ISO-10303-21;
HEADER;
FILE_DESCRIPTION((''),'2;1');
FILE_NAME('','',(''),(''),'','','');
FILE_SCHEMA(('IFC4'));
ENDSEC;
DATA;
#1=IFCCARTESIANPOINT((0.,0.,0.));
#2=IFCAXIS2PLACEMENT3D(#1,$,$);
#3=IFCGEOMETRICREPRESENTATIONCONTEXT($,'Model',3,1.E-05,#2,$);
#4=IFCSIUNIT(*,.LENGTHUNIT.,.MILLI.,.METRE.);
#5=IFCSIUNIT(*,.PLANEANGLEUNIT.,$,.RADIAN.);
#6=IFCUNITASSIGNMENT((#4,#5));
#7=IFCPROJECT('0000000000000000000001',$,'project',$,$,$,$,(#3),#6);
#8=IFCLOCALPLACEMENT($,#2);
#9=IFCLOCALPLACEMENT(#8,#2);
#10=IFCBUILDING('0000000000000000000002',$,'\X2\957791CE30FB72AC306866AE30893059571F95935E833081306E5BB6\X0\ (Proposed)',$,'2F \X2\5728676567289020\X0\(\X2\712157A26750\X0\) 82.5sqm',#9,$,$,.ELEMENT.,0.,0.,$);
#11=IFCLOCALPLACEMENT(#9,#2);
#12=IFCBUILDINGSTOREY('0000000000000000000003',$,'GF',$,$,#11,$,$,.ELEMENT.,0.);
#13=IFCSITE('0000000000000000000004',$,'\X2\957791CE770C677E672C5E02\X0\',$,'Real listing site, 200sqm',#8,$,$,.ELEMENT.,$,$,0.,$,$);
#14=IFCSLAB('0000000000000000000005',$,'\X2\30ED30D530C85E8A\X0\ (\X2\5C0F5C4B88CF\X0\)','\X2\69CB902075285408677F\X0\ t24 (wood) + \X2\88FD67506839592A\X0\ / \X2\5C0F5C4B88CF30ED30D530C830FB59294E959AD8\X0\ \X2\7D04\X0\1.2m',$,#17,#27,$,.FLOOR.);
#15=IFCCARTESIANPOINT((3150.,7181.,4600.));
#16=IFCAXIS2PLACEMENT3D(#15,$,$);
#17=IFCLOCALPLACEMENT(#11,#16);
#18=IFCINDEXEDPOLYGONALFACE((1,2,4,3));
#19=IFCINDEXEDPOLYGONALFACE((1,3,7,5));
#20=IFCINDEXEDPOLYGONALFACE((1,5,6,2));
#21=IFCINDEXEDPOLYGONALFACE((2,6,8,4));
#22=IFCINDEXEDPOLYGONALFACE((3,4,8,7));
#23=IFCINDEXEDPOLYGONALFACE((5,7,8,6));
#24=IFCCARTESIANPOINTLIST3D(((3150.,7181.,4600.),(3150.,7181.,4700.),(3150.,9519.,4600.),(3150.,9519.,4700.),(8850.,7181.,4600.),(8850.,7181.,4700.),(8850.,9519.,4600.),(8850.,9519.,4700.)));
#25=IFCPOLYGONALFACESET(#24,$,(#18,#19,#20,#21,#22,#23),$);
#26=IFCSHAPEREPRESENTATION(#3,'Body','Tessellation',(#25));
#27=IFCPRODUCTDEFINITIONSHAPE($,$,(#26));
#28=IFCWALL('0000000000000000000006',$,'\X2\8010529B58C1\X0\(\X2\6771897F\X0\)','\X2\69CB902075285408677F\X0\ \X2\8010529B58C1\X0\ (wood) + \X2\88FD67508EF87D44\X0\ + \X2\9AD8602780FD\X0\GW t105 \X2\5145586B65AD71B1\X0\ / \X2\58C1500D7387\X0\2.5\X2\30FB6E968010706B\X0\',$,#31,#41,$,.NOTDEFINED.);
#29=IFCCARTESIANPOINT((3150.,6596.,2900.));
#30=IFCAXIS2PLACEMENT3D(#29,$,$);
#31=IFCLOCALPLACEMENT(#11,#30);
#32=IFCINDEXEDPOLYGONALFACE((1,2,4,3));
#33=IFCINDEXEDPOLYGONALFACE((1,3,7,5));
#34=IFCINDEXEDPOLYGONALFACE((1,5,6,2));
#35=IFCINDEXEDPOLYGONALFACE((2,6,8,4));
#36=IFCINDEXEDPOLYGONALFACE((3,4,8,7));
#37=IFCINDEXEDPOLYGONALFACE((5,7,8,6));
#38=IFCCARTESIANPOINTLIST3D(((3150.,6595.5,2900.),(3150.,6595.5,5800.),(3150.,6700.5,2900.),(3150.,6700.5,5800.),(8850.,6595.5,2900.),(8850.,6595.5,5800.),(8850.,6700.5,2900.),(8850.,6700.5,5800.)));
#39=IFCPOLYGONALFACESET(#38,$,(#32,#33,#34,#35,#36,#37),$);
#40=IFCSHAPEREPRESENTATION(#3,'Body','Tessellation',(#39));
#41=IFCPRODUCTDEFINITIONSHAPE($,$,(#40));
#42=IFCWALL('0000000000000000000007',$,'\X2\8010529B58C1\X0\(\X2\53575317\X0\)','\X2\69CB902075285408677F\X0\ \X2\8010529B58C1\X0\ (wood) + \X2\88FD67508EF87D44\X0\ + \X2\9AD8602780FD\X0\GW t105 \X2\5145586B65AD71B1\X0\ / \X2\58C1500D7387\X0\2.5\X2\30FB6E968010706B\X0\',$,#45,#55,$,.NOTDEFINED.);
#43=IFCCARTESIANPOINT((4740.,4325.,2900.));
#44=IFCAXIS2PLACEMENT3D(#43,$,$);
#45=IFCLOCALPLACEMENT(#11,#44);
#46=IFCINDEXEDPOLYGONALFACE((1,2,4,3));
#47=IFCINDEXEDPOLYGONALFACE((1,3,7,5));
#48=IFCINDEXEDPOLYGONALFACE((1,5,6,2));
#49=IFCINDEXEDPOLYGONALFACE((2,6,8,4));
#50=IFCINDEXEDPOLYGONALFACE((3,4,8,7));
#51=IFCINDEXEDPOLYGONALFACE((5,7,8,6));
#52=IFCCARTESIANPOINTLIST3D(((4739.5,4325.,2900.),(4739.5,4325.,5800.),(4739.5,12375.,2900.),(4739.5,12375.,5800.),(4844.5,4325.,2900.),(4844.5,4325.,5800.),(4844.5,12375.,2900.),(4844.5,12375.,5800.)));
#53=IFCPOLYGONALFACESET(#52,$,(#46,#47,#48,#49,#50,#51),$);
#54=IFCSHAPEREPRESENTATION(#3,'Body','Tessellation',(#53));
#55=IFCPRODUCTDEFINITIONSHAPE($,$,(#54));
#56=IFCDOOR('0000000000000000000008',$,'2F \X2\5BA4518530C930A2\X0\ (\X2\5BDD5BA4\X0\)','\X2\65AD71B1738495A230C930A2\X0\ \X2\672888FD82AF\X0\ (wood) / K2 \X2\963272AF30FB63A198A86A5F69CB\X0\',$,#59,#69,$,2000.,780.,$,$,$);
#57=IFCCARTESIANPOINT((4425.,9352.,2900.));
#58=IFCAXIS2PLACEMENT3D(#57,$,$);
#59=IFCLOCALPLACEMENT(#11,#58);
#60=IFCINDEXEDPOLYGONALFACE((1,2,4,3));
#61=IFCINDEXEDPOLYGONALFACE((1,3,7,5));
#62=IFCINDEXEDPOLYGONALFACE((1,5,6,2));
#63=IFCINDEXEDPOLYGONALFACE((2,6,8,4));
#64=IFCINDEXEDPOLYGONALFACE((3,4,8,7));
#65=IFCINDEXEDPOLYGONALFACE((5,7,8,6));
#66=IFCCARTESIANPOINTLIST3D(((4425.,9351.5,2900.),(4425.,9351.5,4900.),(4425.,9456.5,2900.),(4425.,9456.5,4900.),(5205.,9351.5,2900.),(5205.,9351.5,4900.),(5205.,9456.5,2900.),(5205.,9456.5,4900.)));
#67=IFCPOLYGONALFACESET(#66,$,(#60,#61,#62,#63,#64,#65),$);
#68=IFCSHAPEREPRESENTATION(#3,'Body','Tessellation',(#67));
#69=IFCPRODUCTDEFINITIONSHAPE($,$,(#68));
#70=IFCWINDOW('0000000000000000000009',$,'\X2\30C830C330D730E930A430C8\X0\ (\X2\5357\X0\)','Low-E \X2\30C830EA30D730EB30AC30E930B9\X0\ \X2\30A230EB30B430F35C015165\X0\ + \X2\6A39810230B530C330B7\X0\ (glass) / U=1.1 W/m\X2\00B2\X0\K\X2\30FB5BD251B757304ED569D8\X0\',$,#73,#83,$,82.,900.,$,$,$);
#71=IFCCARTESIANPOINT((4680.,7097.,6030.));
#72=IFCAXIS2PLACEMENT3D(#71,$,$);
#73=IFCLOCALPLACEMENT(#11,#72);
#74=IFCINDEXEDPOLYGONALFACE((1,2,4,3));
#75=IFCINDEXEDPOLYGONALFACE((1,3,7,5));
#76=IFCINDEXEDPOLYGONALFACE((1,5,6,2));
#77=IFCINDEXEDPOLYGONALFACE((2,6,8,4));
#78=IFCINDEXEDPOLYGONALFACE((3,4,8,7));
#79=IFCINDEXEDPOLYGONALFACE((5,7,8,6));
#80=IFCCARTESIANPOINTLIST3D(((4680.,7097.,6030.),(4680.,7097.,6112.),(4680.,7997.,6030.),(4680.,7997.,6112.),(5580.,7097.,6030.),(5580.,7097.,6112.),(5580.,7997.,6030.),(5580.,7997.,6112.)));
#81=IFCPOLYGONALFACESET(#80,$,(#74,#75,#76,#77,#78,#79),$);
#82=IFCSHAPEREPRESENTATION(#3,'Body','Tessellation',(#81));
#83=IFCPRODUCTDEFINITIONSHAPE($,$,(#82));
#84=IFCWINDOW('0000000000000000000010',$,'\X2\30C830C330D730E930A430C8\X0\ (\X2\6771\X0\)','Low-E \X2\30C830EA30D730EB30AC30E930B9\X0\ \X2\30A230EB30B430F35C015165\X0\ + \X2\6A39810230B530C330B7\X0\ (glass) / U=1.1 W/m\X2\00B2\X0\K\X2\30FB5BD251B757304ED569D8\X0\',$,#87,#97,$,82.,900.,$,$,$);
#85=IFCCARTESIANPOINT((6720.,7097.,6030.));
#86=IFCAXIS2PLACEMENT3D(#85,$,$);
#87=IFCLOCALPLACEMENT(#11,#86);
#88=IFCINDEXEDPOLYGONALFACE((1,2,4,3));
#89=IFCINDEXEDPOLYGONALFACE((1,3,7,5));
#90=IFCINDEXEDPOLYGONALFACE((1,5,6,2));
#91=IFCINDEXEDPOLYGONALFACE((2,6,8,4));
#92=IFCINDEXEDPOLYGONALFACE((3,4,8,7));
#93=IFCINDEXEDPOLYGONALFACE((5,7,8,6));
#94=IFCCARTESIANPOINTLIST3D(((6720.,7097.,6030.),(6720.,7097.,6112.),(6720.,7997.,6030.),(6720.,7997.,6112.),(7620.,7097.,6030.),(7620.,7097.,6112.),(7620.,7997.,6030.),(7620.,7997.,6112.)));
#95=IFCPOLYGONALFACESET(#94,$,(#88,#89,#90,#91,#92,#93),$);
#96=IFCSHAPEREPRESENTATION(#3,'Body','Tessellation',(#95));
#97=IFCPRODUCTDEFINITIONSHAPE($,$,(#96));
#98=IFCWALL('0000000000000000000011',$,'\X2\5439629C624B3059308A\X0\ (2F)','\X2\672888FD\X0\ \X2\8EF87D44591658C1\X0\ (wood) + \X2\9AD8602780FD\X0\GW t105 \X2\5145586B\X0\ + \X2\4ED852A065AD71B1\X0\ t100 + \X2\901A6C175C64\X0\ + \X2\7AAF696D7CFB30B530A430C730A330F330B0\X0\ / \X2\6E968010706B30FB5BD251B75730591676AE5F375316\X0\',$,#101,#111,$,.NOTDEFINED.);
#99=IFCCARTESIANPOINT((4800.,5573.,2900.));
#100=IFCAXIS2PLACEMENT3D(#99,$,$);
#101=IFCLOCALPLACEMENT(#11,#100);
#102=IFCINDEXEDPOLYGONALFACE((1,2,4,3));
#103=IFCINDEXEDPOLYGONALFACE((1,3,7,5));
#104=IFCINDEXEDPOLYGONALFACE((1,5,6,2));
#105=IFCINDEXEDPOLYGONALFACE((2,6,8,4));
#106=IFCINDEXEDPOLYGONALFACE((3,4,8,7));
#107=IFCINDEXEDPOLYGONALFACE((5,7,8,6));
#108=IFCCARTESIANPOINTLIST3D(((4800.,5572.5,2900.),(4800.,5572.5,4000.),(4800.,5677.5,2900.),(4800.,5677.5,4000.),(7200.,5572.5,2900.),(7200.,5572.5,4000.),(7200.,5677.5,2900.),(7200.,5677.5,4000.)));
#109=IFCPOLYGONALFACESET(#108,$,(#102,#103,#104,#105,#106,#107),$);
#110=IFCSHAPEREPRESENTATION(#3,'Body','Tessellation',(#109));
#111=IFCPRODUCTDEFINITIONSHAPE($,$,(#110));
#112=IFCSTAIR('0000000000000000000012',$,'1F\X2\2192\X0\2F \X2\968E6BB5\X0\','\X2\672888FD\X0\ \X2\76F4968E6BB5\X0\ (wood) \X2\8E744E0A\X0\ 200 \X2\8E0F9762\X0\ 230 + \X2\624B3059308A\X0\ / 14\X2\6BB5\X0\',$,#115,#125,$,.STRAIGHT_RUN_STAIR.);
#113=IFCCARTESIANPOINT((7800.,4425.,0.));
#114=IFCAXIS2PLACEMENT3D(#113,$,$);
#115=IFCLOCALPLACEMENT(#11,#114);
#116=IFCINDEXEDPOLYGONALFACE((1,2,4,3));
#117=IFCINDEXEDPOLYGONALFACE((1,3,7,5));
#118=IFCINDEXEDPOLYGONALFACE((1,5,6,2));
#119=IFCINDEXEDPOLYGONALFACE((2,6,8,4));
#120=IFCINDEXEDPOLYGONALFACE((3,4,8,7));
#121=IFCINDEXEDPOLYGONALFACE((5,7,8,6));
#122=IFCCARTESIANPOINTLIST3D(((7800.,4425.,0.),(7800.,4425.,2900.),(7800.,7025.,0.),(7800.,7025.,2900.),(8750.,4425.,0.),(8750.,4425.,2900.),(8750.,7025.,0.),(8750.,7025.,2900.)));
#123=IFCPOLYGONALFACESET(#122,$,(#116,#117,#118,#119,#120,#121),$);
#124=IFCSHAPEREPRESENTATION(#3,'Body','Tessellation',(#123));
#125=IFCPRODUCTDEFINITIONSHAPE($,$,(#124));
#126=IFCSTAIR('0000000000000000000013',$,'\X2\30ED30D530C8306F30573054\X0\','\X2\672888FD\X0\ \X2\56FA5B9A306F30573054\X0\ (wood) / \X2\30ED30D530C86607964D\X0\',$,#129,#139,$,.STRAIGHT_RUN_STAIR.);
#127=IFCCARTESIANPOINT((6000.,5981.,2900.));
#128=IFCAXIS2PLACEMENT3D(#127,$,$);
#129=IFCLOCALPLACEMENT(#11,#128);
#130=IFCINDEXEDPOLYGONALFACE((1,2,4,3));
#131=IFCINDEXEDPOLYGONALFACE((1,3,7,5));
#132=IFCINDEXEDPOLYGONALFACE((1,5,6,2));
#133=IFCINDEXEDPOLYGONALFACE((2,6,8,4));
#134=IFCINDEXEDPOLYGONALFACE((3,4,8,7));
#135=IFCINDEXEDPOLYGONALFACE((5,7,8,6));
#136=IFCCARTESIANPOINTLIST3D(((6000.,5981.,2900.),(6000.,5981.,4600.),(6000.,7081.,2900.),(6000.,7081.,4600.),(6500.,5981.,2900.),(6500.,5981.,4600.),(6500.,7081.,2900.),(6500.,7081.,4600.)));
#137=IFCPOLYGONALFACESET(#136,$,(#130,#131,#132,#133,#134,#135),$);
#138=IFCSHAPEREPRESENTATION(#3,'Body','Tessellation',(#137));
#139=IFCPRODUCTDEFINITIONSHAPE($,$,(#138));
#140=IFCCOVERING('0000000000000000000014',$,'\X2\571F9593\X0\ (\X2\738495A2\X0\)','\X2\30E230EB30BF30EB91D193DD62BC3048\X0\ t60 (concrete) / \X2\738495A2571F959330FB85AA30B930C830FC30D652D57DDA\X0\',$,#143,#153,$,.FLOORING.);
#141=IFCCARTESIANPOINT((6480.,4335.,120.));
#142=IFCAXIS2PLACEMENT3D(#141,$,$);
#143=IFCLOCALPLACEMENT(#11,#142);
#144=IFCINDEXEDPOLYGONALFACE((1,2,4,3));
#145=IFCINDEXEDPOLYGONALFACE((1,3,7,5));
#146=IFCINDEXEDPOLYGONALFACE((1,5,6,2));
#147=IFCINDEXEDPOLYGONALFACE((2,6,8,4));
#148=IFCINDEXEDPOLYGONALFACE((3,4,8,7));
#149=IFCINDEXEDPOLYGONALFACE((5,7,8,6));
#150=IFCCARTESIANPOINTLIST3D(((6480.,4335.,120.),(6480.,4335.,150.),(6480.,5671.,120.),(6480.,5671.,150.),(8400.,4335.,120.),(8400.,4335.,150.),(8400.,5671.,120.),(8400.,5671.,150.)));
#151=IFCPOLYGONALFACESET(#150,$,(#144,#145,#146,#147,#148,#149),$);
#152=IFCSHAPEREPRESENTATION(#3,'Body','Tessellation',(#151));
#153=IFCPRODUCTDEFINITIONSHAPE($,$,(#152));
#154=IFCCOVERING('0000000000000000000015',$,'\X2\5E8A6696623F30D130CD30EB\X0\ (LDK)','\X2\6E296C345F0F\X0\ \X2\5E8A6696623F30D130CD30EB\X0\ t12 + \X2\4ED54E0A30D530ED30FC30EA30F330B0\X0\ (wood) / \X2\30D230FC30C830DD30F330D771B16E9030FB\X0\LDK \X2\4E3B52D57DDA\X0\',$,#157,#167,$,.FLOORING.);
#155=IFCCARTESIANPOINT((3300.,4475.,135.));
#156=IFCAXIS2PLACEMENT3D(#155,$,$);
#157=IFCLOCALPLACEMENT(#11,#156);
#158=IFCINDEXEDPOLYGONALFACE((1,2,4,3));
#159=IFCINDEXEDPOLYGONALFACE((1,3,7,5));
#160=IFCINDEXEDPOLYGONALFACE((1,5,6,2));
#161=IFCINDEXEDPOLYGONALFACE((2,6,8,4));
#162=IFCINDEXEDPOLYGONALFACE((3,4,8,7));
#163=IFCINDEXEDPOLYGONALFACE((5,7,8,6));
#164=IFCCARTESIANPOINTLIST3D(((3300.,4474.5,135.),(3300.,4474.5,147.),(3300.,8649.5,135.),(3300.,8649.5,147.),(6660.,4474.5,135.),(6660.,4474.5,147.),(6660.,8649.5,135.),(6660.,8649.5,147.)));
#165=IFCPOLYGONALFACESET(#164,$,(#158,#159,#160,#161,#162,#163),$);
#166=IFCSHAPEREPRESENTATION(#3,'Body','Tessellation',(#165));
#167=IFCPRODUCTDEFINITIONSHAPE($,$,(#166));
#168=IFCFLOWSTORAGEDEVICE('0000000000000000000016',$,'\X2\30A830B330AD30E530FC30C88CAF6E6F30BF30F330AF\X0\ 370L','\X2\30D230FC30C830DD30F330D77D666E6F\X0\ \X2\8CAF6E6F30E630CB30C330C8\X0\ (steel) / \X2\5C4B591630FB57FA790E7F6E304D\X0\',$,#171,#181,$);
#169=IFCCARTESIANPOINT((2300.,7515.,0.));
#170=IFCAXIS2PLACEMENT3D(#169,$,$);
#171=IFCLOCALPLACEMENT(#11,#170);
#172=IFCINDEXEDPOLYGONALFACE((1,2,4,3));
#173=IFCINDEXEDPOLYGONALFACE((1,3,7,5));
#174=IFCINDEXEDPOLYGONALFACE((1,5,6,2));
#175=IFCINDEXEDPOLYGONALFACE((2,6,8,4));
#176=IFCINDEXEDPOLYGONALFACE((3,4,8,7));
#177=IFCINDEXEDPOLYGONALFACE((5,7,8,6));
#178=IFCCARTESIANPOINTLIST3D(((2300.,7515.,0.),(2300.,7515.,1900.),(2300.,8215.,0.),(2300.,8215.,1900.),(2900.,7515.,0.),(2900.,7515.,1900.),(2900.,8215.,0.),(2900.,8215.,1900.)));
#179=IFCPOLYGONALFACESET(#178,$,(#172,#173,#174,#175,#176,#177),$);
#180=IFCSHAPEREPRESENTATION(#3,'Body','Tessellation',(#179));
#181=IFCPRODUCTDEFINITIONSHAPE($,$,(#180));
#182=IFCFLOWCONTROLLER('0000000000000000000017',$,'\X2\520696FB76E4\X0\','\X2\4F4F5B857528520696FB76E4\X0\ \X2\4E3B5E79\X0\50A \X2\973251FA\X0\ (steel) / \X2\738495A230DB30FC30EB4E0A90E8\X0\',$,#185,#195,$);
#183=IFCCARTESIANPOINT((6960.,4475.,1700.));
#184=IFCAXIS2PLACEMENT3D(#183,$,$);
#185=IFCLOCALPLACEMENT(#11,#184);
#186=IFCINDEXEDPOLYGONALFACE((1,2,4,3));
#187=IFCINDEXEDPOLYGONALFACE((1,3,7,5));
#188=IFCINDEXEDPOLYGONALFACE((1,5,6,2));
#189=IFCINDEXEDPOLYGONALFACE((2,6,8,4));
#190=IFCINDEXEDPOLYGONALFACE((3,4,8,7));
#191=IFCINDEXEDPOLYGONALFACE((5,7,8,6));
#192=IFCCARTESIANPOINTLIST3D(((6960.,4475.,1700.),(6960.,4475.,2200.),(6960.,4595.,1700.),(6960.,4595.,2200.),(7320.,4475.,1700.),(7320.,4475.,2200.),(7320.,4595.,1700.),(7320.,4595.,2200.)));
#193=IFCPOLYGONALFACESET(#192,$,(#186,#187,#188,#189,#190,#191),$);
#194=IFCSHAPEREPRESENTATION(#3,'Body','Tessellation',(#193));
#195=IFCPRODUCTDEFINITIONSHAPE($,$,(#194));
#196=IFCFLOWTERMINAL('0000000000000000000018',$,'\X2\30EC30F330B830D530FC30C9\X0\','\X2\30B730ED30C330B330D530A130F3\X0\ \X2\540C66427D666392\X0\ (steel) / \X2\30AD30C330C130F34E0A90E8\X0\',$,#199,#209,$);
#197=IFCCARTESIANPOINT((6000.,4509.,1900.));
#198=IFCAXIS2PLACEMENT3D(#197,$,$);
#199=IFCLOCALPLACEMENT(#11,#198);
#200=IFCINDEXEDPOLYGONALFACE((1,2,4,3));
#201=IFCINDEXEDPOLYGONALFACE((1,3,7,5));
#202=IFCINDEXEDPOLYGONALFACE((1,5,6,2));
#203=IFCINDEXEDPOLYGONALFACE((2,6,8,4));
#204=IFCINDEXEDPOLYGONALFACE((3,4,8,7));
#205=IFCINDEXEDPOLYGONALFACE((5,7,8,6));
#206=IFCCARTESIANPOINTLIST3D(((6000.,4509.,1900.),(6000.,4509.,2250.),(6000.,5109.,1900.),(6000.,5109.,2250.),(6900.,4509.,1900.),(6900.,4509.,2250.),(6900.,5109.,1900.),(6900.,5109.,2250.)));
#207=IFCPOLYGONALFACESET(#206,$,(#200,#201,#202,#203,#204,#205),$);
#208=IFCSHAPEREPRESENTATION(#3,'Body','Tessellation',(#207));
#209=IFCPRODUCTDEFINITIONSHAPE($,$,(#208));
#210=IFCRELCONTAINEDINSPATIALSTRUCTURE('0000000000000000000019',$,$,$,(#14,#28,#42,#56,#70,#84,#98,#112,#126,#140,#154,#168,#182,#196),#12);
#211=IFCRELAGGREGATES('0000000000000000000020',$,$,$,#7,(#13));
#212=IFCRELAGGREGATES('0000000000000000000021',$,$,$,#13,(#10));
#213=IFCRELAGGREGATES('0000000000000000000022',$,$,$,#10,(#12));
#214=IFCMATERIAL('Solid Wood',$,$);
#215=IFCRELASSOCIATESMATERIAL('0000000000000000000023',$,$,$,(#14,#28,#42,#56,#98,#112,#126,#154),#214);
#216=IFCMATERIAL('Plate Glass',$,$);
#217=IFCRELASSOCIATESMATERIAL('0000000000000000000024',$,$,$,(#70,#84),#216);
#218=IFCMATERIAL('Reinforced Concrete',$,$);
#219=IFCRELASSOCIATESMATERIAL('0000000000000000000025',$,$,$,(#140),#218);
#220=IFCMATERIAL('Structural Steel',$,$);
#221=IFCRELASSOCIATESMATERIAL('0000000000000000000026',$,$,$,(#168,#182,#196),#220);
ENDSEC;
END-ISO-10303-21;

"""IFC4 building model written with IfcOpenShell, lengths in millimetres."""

from ifc_helpers import new_model, si_unit, frame, frame_2d, origin, place, context, project, spatial, rectangle, extrude, material, element, fill, save


model = new_model("IFC4")

# Units and contexts
model_context = context("Model", 3, precision=1e-05, world=origin())
ifc_project = project(units=[si_unit("LENGTHUNIT", "METRE", prefix="MILLI"), si_unit("PLANEANGLEUNIT", "RADIAN")], contexts=[model_context])

# Site, building, storey
site_placement = place(None, origin())
site = spatial("IfcSite", under=ifc_project, at=site_placement, Name="長野県松本市", ObjectType="Real listing site, 200sqm", CompositionType="ELEMENT", RefElevation=0.0)
building_placement = place(site_placement, origin())
building = spatial("IfcBuilding", under=site, at=building_placement, Name="長野・犬と暮らす土間広めの家 (Proposed)", ObjectType="2F 在来木造(無垢材) 82.5sqm", CompositionType="ELEMENT", ElevationOfRefHeight=0.0, ElevationOfTerrain=0.0)
storey_placement = place(building_placement, origin())
storey = spatial("IfcBuildingStorey", under=building, at=storey_placement, Name="GF", CompositionType="ELEMENT", Elevation=0.0)

# Shared definitions
ifc_material_1 = material(Name="Solid Wood")

# Slab
slab_placement = place(storey_placement, frame((3150.0, 7181.0, 4600.0)))
element("IfcSlab", 1, at=slab_placement, inside=storey, material=ifc_material_1, Name="ロフト床 (小屋裏)", Description="構造用合板 t24 (wood) + 製材根太 / 小屋裏ロフト・天井高 約1.2m", PredefinedType="FLOOR", context=model_context, shape_type="SweptSolid", body=[
    extrude(rectangle(XDim=5700.0, YDim=2338.0, at=frame_2d((2850.0, 1169.0))), frame((3150.0, 7181.0, 4600.0)), (0.0, 0.0, 1.0), 100.0),
])

# Wall
wall_1_placement = place(storey_placement, frame((3150.0, 6596.0, 2900.0)))
element("IfcWall", 2, at=wall_1_placement, inside=storey, material=ifc_material_1, Name="耐力壁(東西)", Description="構造用合板 耐力壁 (wood) + 製材軸組 + 高性能GW t105 充填断熱 / 壁倍率2.5・準耐火", PredefinedType="NOTDEFINED", context=model_context, shape_type="SweptSolid", body=[
    extrude(rectangle(XDim=5700.0, YDim=105.0, at=frame_2d((2850.0, 52.0))), frame((3150.0, 6596.0, 2900.0)), (0.0, 0.0, 1.0), 2900.0),
])

# Wall, opening, door
wall_2_placement = place(storey_placement, frame((4740.0, 4325.0, 2900.0)))
wall_2 = element("IfcWall", 3, at=wall_2_placement, inside=storey, material=ifc_material_1, Name="耐力壁(南北)", Description="構造用合板 耐力壁 (wood) + 製材軸組 + 高性能GW t105 充填断熱 / 壁倍率2.5・準耐火", PredefinedType="NOTDEFINED", context=model_context, shape_type="SweptSolid", body=[
    extrude(rectangle(XDim=105.0, YDim=8050.0, at=frame_2d((52.0, 4025.0))), frame((4740.0, 4325.0, 2900.0)), (0.0, 0.0, 1.0), 2900.0),
])
opening_placement = place(storey_placement, frame((4425.0, 9352.0, 2900.0)))
opening = element("IfcOpeningElement", 4, at=opening_placement, cuts=wall_2, PredefinedType="NOTDEFINED", context=model_context, shape_type="SweptSolid", body=[
    extrude(rectangle(XDim=780.0, YDim=105.0, at=frame_2d((390.0, 52.0))), frame((4425.0, 9352.0, 2900.0)), (0.0, 0.0, 1.0), 2000.0),
])
door_placement = place(storey_placement, frame((4425.0, 9352.0, 2900.0)))
door = element("IfcDoor", 5, at=door_placement, inside=storey, material=ifc_material_1, Name="2F 室内ドア (寝室)", Description="断熱玄関ドア 木製芯 (wood) / K2 防犯・採風機構", OverallHeight=2000.0, OverallWidth=780.0, context=model_context, shape_type="SweptSolid", body=[
    extrude(rectangle(XDim=780.0, YDim=105.0, at=frame_2d((390.0, 52.0))), frame((4425.0, 9352.0, 2900.0)), (0.0, 0.0, 1.0), 2000.0),
])
fill(opening, door)

# Windows
ifc_material_2 = material(Name="Plate Glass")
window_1_placement = place(storey_placement, frame((4680.0, 7097.0, 6030.0)))
element("IfcWindow", 6, at=window_1_placement, inside=storey, material=ifc_material_2, Name="トップライト (南)", Description="Low-E トリプルガラス アルゴン封入 + 樹脂サッシ (glass) / U=1.1 W/m²K・寒冷地仕様", OverallHeight=82.0, OverallWidth=900.0, context=model_context, shape_type="SweptSolid", body=[
    extrude(rectangle(XDim=900.0, YDim=900.0, at=frame_2d((450.0, 450.0))), frame((4680.0, 7097.0, 6030.0)), (0.0, 0.0, 1.0), 82.0),
])
window_2_placement = place(storey_placement, frame((6720.0, 7097.0, 6030.0)))
element("IfcWindow", 7, at=window_2_placement, inside=storey, material=ifc_material_2, Name="トップライト (東)", Description="Low-E トリプルガラス アルゴン封入 + 樹脂サッシ (glass) / U=1.1 W/m²K・寒冷地仕様", OverallHeight=82.0, OverallWidth=900.0, context=model_context, shape_type="SweptSolid", body=[
    extrude(rectangle(XDim=900.0, YDim=900.0, at=frame_2d((450.0, 450.0))), frame((6720.0, 7097.0, 6030.0)), (0.0, 0.0, 1.0), 82.0),
])

# Wall
wall_3_placement = place(storey_placement, frame((4800.0, 5573.0, 2900.0)))
element("IfcWall", 8, at=wall_3_placement, inside=storey, material=ifc_material_1, Name="吹抜手すり (2F)", Description="木製 軸組外壁 (wood) + 高性能GW t105 充填 + 付加断熱 t100 + 通気層 + 窯業系サイディング / 準耐火・寒冷地外皮強化", PredefinedType="NOTDEFINED", context=model_context, shape_type="SweptSolid", body=[
    extrude(rectangle(XDim=2400.0, YDim=105.0, at=frame_2d((1200.0, 52.0))), frame((4800.0, 5573.0, 2900.0)), (0.0, 0.0, 1.0), 1100.0),
])

# Stairs
stair_1_placement = place(storey_placement, frame((7800.0, 4425.0, 0.0)))
element("IfcStair", 9, at=stair_1_placement, inside=storey, material=ifc_material_1, Name="1F→2F 階段", Description="木製 直階段 (wood) 蹴上 200 踏面 230 + 手すり / 14段", PredefinedType="STRAIGHT_RUN_STAIR", context=model_context, shape_type="SweptSolid", body=[
    extrude(rectangle(XDim=950.0, YDim=2600.0, at=frame_2d((475.0, 1300.0))), frame((7800.0, 4425.0, 0.0)), (0.0, 0.0, 1.0), 2900.0),
])
stair_2_placement = place(storey_placement, frame((6000.0, 5981.0, 2900.0)))
element("IfcStair", 10, at=stair_2_placement, inside=storey, material=ifc_material_1, Name="ロフトはしご", Description="木製 固定はしご (wood) / ロフト昇降", PredefinedType="STRAIGHT_RUN_STAIR", context=model_context, shape_type="SweptSolid", body=[
    extrude(rectangle(XDim=500.0, YDim=1100.0, at=frame_2d((250.0, 550.0))), frame((6000.0, 5981.0, 2900.0)), (0.0, 0.0, 1.0), 1700.0),
])

# Coverings
ifc_material_3 = material(Name="Reinforced Concrete")
covering_1_placement = place(storey_placement, frame((6480.0, 4335.0, 120.0)))
element("IfcCovering", 11, at=covering_1_placement, inside=storey, material=ifc_material_3, Name="土間 (玄関)", Description="モルタル金鏝押え t60 (concrete) / 玄関土間・薪ストーブ動線", PredefinedType="FLOORING", context=model_context, shape_type="SweptSolid", body=[
    extrude(rectangle(XDim=1920.0, YDim=1336.0, at=frame_2d((960.0, 668.0))), frame((6480.0, 4335.0, 120.0)), (0.0, 0.0, 1.0), 30.0),
])
covering_2_placement = place(storey_placement, frame((3300.0, 4475.0, 135.0)))
element("IfcCovering", 12, at=covering_2_placement, inside=storey, material=ifc_material_1, Name="床暖房パネル (LDK)", Description="温水式 床暖房パネル t12 + 仕上フローリング (wood) / ヒートポンプ熱源・LDK 主動線", PredefinedType="FLOORING", context=model_context, shape_type="SweptSolid", body=[
    extrude(rectangle(XDim=3360.0, YDim=4175.0, at=frame_2d((1680.0, 2087.0))), frame((3300.0, 4475.0, 135.0)), (0.0, 0.0, 1.0), 12.0),
])

# Flow storage device
ifc_material_4 = material(Name="Structural Steel")
flow_storage_device_placement = place(storey_placement, frame((2300.0, 7515.0, 0.0)))
element("IfcFlowStorageDevice", 13, at=flow_storage_device_placement, inside=storey, material=ifc_material_4, Name="エコキュート貯湯タンク 370L", Description="ヒートポンプ給湯 貯湯ユニット (steel) / 屋外・基礎置き", context=model_context, shape_type="SweptSolid", body=[
    extrude(rectangle(XDim=600.0, YDim=700.0, at=frame_2d((300.0, 350.0))), frame((2300.0, 7515.0, 0.0)), (0.0, 0.0, 1.0), 1900.0),
])

# Flow controller
flow_controller_placement = place(storey_placement, frame((6960.0, 4475.0, 1700.0)))
element("IfcFlowController", 14, at=flow_controller_placement, inside=storey, material=ifc_material_4, Name="分電盤", Description="住宅用分電盤 主幹50A 露出 (steel) / 玄関ホール上部", context=model_context, shape_type="SweptSolid", body=[
    extrude(rectangle(XDim=360.0, YDim=120.0, at=frame_2d((180.0, 60.0))), frame((6960.0, 4475.0, 1700.0)), (0.0, 0.0, 1.0), 500.0),
])

# Flow terminal
flow_terminal_1_placement = place(storey_placement, frame((6000.0, 4509.0, 1900.0)))
element("IfcFlowTerminal", 15, at=flow_terminal_1_placement, inside=storey, material=ifc_material_4, Name="レンジフード", Description="シロッコファン 同時給排 (steel) / キッチン上部", context=model_context, shape_type="SweptSolid", body=[
    extrude(rectangle(XDim=900.0, YDim=600.0, at=frame_2d((450.0, 300.0))), frame((6000.0, 4509.0, 1900.0)), (0.0, 0.0, 1.0), 350.0),
])

save(model, "model.ifc")
